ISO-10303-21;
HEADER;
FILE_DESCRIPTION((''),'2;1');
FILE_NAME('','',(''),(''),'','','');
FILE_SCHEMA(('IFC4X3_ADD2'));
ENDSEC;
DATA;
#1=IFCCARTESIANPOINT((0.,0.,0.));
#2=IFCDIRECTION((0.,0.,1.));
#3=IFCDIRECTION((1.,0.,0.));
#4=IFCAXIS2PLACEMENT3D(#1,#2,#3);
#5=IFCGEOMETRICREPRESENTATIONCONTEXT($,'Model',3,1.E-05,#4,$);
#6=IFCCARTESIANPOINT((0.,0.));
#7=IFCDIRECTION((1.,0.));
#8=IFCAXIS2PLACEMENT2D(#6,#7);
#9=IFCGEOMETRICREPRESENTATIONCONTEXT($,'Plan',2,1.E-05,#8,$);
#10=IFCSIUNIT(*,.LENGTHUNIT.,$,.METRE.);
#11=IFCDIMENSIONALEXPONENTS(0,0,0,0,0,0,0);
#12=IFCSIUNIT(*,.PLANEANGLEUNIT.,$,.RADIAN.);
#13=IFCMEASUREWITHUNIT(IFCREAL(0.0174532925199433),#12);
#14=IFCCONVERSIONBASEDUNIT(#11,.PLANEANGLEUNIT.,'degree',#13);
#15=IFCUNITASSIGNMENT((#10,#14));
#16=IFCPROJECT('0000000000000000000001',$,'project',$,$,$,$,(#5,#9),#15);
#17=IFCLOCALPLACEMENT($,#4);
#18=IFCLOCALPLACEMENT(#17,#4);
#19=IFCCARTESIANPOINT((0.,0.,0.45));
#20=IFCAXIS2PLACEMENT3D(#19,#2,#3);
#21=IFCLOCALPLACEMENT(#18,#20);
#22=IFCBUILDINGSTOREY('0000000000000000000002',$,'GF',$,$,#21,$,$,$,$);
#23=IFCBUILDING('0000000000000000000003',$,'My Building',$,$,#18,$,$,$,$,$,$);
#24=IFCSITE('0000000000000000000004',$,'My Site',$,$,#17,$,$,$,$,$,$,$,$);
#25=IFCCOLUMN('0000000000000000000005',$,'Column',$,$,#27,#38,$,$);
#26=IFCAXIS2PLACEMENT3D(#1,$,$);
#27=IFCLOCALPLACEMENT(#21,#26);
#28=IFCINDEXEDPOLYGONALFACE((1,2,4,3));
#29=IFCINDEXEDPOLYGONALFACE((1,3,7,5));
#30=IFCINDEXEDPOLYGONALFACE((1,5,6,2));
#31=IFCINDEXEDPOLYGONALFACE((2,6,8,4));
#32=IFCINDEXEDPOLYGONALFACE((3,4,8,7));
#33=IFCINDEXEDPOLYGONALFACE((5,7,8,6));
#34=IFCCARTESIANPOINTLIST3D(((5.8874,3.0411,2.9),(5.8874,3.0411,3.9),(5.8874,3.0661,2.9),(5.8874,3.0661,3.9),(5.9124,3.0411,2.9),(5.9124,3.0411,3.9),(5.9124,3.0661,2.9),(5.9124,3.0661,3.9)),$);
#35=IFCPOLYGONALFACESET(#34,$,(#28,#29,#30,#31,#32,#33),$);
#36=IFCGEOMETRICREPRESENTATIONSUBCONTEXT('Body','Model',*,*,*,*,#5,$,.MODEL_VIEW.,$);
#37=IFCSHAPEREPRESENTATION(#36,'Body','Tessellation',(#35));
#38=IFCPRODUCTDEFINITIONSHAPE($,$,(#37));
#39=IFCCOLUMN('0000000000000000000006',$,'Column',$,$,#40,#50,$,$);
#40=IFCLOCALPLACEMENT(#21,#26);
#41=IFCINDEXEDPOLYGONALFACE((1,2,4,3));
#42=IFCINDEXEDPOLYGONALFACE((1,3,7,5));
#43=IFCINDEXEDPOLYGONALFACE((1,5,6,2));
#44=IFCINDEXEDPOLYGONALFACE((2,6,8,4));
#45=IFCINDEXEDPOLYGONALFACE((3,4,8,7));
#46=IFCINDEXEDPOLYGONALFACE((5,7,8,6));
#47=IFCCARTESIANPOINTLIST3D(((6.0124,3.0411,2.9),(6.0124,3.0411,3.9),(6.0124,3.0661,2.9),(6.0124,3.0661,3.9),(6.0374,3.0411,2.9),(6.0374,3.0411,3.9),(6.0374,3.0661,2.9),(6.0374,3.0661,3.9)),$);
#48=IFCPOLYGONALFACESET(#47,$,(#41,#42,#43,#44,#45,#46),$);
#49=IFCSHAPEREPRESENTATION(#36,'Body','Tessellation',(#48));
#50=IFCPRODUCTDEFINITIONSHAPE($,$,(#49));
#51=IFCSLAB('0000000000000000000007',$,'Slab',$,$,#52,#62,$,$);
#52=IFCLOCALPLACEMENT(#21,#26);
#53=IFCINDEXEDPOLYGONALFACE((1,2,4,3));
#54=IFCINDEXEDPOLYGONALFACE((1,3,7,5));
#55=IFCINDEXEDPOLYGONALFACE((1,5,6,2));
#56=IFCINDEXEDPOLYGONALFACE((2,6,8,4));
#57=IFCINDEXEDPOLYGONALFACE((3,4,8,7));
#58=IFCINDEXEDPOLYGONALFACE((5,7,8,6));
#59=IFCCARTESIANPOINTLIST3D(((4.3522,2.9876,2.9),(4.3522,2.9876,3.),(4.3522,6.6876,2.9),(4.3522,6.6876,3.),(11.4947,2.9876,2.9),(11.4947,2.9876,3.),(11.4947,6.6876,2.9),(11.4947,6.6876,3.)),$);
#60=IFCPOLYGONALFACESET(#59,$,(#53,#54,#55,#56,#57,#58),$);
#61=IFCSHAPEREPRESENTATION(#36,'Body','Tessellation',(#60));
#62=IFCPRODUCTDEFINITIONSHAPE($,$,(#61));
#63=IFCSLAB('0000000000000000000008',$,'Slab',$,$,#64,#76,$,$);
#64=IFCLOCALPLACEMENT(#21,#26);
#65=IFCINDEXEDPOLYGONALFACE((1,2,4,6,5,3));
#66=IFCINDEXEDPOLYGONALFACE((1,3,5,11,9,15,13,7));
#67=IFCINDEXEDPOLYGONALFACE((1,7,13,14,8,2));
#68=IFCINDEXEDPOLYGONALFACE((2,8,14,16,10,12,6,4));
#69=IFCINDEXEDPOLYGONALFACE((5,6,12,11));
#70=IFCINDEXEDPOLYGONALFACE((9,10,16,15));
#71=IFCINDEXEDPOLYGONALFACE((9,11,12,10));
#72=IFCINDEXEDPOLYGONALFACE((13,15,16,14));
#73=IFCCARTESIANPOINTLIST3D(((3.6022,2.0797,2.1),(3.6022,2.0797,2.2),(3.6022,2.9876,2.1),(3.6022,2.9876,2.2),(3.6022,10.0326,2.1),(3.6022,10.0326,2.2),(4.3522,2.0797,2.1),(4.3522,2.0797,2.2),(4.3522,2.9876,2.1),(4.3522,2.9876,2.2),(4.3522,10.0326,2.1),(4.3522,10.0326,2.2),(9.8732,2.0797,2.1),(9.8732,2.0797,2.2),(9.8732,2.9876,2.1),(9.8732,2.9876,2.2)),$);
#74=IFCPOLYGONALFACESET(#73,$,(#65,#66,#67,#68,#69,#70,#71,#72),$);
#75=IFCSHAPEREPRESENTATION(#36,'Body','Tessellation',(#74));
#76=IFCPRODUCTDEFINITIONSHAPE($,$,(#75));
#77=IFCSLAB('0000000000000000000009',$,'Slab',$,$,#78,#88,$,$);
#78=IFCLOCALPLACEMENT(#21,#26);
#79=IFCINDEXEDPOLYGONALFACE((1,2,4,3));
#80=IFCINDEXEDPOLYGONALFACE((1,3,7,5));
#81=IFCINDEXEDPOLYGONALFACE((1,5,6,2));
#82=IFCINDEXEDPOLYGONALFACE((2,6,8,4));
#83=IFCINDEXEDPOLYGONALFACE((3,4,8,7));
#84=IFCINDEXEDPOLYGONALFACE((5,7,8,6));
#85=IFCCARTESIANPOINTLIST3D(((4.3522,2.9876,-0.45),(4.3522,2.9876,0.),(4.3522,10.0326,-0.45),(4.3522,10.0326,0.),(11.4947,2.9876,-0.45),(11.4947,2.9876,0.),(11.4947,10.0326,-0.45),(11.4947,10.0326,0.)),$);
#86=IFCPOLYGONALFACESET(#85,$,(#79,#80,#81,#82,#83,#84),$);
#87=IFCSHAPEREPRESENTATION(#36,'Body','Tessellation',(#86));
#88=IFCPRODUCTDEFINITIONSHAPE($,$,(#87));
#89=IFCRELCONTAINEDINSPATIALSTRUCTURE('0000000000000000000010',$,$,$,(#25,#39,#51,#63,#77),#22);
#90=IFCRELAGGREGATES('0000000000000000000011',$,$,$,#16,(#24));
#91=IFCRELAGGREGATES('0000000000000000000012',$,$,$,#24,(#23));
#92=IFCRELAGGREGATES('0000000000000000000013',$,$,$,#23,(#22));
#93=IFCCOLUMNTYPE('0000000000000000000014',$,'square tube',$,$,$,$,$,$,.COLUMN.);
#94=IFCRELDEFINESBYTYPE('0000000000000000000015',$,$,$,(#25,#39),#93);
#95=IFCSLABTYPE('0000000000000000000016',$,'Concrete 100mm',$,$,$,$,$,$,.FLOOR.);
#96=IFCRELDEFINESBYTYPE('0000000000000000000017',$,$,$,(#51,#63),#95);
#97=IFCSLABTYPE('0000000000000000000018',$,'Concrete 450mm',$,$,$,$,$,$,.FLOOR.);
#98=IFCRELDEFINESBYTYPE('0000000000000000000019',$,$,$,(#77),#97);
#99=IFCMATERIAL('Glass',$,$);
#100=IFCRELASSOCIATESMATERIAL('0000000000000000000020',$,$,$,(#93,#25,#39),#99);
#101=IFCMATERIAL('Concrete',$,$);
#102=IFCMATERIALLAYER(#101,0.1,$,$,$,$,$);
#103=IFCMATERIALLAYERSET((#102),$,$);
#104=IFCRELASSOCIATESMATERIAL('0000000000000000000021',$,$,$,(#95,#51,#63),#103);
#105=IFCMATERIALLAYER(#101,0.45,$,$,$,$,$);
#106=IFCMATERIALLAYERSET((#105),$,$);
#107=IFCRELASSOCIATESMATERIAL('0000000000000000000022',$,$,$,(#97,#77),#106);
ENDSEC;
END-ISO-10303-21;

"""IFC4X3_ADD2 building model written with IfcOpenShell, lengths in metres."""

from ifc_helpers import new_model, entity, si_unit, converted_unit, frame, origin_with_axes, origin_2d_with_axis, place, context, subcontext, project, spatial, indexed_curve, rectangle, outline, extrude, material, layer, layer_set, layer_usage, material_profile, profile_set, profile_usage, type_object, element, save


model = new_model("IFC4X3_ADD2")

# Units and contexts
model_context = context("Model", 3, precision=1e-05, world=origin_with_axes())
plan_context = context("Plan", 2, precision=1e-05, world=origin_2d_with_axis())
body_context_1 = subcontext(model_context, "Body", "Model", "MODEL_VIEW")
ifc_project = project(units=[si_unit("LENGTHUNIT", "METRE"), converted_unit("PLANEANGLEUNIT", "degree", entity("IfcReal", 0.0174532925199433), si_unit("PLANEANGLEUNIT", "RADIAN"), dimensions=[0, 0, 0, 0, 0, 0, 0])], contexts=[model_context, plan_context])

# Site, building, storey
site_placement = place(None, origin_with_axes())
site = spatial("IfcSite", under=ifc_project, at=site_placement, Name="My Site")
building_placement = place(site_placement, origin_with_axes())
building = spatial("IfcBuilding", under=site, at=building_placement, Name="My Building")
storey_placement = place(building_placement, frame((0.0, 0.0, 0.45), z_axis=(0.0, 0.0, 1.0), x_axis=(1.0, 0.0, 0.0)))
storey = spatial("IfcBuildingStorey", under=building, at=storey_placement, Name="GF")

# Columns
ifc_material_1 = material(Name="Glass")
ifc_material_profile = material_profile(ifc_material_1, rectangle(XDim=0.025, YDim=0.025))
ifc_profile_set = profile_set([ifc_material_profile])
column_type = type_object("IfcColumnType", Name="square tube", PredefinedType="COLUMN", material=ifc_profile_set)
ifc_profile_usage_1 = profile_usage(ifc_profile_set, cardinal=5)
column_1_placement = place(storey_placement, frame((5.8999, 3.0536, 2.9), z_axis=(0.0, 0.0, 1.0), x_axis=(1.0, 0.0, 0.0)))
element("IfcColumn", 1, at=column_1_placement, inside=storey, type_object=column_type, material=ifc_profile_usage_1, Name="Column", context=body_context_1, shape_type="SweptSolid", body=[
    extrude(rectangle(XDim=0.025, YDim=0.025), origin_with_axes(), (0.0, 0.0, 1.0), 1.0),
])
ifc_profile_usage_2 = profile_usage(ifc_profile_set, cardinal=5)
column_2_placement = place(storey_placement, frame((6.0249, 3.0536, 2.9), z_axis=(0.0, 0.0, 1.0), x_axis=(1.0, 0.0, 0.0)))
element("IfcColumn", 2, at=column_2_placement, inside=storey, type_object=column_type, material=ifc_profile_usage_2, Name="Column", context=body_context_1, shape_type="SweptSolid", body=[
    extrude(rectangle(XDim=0.025, YDim=0.025), origin_with_axes(), (0.0, 0.0, 1.0), 1.0),
])

# Slabs
ifc_material_2 = material(Name="Concrete")
ifc_layer_1 = layer(ifc_material_2, 0.1)
ifc_layer_set_1 = layer_set([ifc_layer_1])
slab_type_1 = type_object("IfcSlabType", Name="Concrete 100mm", PredefinedType="FLOOR", material=ifc_layer_set_1)
ifc_layer_usage_1 = layer_usage(ifc_layer_set_1, "AXIS3", "POSITIVE", 0.0)
slab_1_placement = place(storey_placement, frame((4.3522, 2.9876, 2.9), z_axis=(0.0, 0.0, 1.0), x_axis=(1.0, 0.0, 0.0)))
element("IfcSlab", 3, at=slab_1_placement, inside=storey, type_object=slab_type_1, material=ifc_layer_usage_1, Name="Slab", context=body_context_1, shape_type="SolidModel", body=[
    extrude(outline(indexed_curve([(0.0, 0.0), (7.1425, 0.0), (7.1425, 3.7), (0.0, 3.7), (0.0, 0.0)])), origin_with_axes(), (0.0, 0.0, 1.0), 0.1),
])
ifc_layer_usage_2 = layer_usage(ifc_layer_set_1, "AXIS3", "POSITIVE", 0.0)
slab_2_placement = place(storey_placement, frame((4.3522, 2.0797, 2.1), z_axis=(0.0, 0.0, 1.0), x_axis=(1.0, 0.0, 0.0)))
element("IfcSlab", 4, at=slab_2_placement, inside=storey, type_object=slab_type_1, material=ifc_layer_usage_2, Name="Slab", context=body_context_1, shape_type="SweptSolid", body=[
    extrude(outline(indexed_curve([(0.0, 0.0), (5.521, 0.0), (5.521, 0.9079), (0.0, 0.9079), (0.0, 7.9529), (-0.75, 7.9529), (-0.75, 0.9079), (-0.75, 0.0), (0.0, 0.0)])), origin_with_axes(), (0.0, 0.0, 1.0), 0.1),
])
ifc_layer_2 = layer(ifc_material_2, 0.45)
ifc_layer_set_2 = layer_set([ifc_layer_2])
ifc_layer_usage_3 = layer_usage(ifc_layer_set_2, "AXIS3", "POSITIVE", -0.45)
slab_type_2 = type_object("IfcSlabType", Name="Concrete 450mm", PredefinedType="FLOOR", material=ifc_layer_set_2)
slab_3_placement = place(storey_placement, frame((4.3522, 2.9876, 0.0), z_axis=(0.0, 0.0, 1.0), x_axis=(1.0, 0.0, 0.0)))
element("IfcSlab", 5, at=slab_3_placement, inside=storey, type_object=slab_type_2, material=ifc_layer_usage_3, Name="Slab", context=body_context_1, shape_type="SolidModel", body=[
    extrude(outline(indexed_curve([(0.0, 0.0), (7.1425, 0.0), (7.1425, 7.045), (0.0, 7.045), (0.0, 0.0)])), frame((0.0, 0.0, -0.45), z_axis=(0.0, 0.0, 1.0), x_axis=(1.0, 0.0, 0.0)), (0.0, 0.0, 1.0), 0.45),
])

save(model, "model.ifc")
